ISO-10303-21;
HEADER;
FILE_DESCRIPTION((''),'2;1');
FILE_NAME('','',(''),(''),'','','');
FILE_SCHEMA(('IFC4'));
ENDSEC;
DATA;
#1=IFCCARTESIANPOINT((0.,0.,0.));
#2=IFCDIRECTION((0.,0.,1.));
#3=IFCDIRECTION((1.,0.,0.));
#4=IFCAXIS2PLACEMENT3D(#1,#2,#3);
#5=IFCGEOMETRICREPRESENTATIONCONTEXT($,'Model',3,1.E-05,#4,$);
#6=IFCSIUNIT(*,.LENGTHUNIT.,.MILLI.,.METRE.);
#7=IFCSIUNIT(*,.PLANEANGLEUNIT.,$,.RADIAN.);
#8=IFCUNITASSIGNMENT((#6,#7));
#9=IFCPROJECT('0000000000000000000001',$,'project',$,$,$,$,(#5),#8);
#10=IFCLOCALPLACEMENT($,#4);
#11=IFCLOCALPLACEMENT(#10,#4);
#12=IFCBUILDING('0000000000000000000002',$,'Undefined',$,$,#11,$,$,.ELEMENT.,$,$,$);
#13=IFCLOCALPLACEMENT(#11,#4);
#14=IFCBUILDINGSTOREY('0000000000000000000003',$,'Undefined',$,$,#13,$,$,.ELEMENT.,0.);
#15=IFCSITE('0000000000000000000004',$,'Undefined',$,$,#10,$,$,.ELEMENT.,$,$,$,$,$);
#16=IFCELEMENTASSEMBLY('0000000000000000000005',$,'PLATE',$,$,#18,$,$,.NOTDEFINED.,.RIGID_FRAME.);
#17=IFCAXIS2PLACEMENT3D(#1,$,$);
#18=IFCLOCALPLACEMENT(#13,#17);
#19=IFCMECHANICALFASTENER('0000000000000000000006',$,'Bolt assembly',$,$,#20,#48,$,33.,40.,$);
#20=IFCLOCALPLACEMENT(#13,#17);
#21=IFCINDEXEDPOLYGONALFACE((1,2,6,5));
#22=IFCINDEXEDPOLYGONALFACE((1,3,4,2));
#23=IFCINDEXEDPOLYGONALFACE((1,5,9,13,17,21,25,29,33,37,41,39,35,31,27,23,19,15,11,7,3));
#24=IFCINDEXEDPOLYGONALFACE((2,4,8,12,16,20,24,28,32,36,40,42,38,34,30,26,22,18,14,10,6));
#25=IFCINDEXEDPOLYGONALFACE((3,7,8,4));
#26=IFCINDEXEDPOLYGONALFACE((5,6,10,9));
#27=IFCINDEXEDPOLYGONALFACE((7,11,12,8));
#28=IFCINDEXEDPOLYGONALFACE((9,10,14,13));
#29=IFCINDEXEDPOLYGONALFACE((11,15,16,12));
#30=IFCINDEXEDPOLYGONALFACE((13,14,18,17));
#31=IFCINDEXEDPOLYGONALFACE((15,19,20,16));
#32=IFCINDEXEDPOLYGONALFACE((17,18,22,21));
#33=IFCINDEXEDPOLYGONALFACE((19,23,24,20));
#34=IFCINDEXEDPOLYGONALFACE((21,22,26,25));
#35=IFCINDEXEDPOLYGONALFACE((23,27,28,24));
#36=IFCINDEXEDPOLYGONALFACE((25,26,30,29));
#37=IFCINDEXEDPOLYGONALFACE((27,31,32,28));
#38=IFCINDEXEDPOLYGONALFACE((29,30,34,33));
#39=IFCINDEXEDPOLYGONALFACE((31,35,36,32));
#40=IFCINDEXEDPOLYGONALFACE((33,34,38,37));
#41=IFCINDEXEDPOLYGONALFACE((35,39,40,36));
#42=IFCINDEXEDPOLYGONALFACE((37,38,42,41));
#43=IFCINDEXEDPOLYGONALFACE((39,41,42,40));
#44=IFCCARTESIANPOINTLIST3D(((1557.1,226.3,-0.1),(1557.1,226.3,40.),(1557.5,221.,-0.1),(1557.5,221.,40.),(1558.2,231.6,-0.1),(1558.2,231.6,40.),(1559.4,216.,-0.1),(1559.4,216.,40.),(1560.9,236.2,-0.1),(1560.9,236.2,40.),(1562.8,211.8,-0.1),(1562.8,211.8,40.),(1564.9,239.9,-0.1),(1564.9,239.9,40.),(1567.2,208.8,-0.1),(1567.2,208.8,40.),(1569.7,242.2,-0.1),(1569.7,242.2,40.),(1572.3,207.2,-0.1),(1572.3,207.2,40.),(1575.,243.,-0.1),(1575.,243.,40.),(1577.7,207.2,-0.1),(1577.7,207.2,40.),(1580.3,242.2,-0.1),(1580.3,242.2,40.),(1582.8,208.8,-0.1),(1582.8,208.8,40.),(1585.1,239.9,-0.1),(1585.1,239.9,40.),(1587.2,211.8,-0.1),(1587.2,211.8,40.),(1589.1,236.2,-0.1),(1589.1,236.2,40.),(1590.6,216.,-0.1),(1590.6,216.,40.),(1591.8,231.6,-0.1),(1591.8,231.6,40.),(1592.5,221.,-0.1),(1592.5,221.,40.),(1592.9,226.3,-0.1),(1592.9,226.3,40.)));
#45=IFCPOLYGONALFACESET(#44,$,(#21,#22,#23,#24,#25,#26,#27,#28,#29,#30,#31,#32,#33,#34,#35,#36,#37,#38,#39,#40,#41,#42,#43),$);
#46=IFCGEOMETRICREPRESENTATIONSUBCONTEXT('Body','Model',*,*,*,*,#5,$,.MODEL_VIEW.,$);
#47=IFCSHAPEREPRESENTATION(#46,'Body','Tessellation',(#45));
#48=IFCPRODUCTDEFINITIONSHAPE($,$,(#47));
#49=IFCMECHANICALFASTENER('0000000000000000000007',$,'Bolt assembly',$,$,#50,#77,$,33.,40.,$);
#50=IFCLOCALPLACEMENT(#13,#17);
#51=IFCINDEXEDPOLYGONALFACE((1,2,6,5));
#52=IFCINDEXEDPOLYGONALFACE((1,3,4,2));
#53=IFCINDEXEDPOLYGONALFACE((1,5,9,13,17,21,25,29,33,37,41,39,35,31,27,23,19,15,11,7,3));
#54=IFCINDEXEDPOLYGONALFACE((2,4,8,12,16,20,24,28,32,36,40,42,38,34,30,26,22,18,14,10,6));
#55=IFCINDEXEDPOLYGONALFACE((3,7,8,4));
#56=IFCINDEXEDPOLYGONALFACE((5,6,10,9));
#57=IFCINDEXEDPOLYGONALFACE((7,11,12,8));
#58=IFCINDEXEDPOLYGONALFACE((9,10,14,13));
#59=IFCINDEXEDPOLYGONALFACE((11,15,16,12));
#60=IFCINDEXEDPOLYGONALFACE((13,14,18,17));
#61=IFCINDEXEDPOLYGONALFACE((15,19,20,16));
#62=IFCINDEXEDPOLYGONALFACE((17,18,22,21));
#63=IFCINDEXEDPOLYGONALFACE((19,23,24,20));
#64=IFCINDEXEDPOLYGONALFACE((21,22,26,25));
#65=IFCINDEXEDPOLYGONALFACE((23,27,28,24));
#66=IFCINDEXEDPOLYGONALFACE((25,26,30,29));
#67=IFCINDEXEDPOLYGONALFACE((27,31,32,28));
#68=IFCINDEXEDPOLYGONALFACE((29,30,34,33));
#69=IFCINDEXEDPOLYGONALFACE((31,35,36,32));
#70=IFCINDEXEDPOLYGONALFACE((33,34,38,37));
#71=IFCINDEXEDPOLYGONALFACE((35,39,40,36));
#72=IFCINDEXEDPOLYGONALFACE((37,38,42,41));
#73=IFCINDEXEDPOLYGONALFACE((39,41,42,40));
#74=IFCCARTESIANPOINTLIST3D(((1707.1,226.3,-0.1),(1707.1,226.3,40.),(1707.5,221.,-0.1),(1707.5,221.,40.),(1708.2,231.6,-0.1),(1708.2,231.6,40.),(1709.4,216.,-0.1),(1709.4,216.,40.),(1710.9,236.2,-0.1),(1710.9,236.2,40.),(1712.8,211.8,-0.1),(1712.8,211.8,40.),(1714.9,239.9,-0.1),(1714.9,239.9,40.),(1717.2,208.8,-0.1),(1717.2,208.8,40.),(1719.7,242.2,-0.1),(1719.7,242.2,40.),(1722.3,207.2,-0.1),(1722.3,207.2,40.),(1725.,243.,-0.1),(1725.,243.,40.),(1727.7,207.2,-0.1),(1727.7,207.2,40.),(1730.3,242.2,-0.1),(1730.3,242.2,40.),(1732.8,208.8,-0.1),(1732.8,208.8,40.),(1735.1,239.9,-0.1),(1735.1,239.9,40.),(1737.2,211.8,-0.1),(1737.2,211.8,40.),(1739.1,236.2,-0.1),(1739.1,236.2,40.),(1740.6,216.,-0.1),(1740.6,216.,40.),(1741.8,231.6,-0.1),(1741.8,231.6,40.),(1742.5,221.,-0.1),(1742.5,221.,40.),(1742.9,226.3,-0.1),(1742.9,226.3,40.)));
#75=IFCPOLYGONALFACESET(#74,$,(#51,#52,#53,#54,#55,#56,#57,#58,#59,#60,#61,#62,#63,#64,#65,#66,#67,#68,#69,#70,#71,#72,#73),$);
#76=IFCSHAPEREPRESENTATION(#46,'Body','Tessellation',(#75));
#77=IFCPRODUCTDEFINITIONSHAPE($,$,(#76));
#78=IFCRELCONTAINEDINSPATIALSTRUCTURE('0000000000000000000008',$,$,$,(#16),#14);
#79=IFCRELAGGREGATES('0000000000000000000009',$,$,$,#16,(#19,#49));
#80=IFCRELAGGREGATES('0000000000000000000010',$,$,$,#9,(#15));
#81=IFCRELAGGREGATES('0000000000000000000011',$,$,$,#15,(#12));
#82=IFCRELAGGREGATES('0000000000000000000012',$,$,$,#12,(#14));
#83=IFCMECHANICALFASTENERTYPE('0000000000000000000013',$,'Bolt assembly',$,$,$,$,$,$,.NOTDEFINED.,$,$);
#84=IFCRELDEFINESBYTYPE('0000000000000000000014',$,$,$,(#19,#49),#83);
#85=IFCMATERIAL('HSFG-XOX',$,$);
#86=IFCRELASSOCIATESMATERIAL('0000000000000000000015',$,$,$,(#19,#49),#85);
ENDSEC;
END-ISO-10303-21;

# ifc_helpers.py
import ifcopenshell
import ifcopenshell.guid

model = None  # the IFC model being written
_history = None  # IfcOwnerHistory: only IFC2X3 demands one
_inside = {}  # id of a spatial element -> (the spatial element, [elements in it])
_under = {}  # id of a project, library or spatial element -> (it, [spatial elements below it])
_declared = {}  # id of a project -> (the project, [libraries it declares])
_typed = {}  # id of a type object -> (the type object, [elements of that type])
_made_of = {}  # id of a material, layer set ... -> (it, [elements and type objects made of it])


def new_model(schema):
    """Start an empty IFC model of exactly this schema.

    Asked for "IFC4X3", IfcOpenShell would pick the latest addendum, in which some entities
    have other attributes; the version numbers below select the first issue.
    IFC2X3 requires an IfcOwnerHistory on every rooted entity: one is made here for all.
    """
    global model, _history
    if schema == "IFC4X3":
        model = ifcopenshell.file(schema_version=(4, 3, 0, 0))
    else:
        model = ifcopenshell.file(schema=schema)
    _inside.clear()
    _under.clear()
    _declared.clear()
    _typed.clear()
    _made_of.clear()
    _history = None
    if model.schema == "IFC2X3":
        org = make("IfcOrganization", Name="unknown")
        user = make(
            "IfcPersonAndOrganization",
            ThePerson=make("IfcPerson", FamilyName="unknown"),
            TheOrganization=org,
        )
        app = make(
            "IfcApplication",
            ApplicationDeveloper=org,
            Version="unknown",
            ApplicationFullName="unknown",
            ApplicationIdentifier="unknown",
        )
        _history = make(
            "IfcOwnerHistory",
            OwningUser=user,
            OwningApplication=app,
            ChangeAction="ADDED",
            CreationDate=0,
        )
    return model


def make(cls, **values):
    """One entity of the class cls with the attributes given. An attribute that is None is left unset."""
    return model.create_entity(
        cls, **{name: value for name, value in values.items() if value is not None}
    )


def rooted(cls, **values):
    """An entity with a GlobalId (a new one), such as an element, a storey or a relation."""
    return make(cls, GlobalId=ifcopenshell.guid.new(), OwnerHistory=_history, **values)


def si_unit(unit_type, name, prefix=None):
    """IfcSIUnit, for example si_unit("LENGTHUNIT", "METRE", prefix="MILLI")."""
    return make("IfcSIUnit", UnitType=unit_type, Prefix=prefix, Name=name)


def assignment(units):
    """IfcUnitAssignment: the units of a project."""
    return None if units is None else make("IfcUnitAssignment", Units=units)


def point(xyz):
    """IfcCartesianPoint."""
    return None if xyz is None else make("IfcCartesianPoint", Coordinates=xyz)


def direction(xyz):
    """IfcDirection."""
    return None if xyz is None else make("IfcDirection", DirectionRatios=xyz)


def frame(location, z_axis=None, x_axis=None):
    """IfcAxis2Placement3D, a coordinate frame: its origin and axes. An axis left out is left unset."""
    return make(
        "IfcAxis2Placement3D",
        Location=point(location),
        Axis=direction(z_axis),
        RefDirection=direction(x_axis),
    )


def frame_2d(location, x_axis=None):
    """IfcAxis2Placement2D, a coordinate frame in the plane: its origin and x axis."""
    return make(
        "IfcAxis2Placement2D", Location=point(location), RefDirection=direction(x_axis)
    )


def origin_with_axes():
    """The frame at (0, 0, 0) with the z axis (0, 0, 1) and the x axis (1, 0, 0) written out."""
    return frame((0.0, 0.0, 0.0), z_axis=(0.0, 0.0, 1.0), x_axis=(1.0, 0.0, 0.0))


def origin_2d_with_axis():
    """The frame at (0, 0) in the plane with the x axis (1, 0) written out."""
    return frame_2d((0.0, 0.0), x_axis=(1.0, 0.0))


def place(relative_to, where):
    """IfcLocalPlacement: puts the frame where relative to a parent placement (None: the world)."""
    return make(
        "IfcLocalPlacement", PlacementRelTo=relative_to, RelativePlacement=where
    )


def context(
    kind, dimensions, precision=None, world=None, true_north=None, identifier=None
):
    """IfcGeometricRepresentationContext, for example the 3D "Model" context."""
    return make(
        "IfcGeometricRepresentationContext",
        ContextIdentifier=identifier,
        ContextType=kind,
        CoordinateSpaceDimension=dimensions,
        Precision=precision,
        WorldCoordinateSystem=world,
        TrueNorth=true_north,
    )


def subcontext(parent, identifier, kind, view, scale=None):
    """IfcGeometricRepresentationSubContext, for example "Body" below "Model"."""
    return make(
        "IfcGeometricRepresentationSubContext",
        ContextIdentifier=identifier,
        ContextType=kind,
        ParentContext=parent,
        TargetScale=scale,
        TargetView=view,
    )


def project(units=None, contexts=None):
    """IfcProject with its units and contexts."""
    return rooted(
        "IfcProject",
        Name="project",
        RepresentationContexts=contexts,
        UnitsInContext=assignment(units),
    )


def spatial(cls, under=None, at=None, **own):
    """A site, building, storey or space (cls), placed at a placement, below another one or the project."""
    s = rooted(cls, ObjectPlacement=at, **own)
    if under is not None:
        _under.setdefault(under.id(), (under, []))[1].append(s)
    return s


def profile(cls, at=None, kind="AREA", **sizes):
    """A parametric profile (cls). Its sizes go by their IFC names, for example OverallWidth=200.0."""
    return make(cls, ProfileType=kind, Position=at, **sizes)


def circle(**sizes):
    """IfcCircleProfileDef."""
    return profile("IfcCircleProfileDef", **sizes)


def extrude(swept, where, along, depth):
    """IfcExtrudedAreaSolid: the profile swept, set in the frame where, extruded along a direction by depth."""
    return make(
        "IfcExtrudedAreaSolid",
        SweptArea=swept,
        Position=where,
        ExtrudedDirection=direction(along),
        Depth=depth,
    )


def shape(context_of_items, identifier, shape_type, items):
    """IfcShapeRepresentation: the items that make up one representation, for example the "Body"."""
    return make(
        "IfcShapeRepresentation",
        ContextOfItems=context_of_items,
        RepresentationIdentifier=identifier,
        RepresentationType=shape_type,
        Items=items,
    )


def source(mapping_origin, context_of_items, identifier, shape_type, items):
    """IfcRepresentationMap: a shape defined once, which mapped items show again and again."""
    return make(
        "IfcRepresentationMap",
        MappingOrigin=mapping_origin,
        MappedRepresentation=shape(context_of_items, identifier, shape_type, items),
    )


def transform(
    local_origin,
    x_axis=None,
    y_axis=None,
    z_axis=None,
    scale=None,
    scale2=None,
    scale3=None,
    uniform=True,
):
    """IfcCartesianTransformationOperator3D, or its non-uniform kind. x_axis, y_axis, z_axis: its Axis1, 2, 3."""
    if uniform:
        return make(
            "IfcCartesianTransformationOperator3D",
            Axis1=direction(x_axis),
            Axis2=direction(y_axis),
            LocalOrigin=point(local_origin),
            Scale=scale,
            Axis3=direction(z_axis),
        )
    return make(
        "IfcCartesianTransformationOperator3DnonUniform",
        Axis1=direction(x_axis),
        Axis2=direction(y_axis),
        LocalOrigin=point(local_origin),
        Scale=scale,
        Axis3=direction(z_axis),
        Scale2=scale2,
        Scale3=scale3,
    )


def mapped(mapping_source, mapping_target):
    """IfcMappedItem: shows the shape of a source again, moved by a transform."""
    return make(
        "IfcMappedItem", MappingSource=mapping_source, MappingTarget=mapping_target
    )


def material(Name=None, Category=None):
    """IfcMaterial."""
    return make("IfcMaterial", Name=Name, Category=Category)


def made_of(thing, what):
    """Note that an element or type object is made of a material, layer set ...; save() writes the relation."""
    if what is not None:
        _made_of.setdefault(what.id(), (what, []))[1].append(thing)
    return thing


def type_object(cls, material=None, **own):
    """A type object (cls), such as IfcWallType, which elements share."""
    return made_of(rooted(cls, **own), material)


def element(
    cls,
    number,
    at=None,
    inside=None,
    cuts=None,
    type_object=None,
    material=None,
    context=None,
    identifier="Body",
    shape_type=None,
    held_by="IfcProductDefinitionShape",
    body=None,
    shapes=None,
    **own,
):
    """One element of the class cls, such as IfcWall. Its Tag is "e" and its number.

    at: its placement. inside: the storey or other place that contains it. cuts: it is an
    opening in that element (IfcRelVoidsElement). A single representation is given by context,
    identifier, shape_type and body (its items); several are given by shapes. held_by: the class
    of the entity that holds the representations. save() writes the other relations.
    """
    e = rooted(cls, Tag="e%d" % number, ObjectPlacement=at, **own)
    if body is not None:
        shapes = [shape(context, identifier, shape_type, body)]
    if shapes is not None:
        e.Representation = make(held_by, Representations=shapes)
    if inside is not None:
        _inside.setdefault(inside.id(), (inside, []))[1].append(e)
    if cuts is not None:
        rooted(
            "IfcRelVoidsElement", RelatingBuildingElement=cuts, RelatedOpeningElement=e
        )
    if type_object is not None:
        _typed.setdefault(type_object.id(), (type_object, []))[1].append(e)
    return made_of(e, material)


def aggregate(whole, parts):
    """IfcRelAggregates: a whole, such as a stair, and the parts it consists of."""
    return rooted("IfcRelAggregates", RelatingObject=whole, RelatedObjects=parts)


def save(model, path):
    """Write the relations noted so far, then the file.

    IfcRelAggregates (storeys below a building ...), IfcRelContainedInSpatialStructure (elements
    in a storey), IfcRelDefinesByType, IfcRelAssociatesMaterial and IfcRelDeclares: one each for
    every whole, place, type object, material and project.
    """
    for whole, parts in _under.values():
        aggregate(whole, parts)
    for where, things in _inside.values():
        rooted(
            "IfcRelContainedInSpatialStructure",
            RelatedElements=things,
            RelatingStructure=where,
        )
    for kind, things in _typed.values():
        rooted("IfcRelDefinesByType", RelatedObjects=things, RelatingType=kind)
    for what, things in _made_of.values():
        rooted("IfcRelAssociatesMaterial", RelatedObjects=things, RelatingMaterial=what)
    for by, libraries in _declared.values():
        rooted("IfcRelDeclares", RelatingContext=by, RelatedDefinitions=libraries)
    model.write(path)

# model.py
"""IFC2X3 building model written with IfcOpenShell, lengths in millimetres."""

from ifc_helpers import new_model, si_unit, frame, origin_with_axes, origin_2d_with_axis, place, context, subcontext, project, spatial, circle, extrude, source, transform, mapped, material, type_object, element, aggregate, save


model = new_model("IFC2X3")

# Units and contexts
model_context = context("Model", 3, precision=1e-05, world=origin_with_axes())
body_context = subcontext(model_context, "Body", "Model", "MODEL_VIEW")
ifc_project = project(units=[si_unit("LENGTHUNIT", "METRE", prefix="MILLI"), si_unit("PLANEANGLEUNIT", "RADIAN")], contexts=[model_context])

# Site, building, storey
site_placement = place(None, origin_with_axes())
site = spatial("IfcSite", under=ifc_project, at=site_placement, Name="Undefined", CompositionType="ELEMENT")
building_placement = place(site_placement, origin_with_axes())
building = spatial("IfcBuilding", under=site, at=building_placement, Name="Undefined", CompositionType="ELEMENT")
storey_placement = place(building_placement, origin_with_axes())
storey = spatial("IfcBuildingStorey", under=building, at=storey_placement, Name="Undefined", CompositionType="ELEMENT", Elevation=0.0)

# Element assembly, mechanical fasteners
assembly_1_placement = place(storey_placement, origin_with_axes())
assembly_1 = element("IfcElementAssembly", 1, at=assembly_1_placement, inside=storey, Name="PLATE", AssemblyPlace="NOTDEFINED", PredefinedType="RIGID_FRAME")
ifc_material_1 = material(Name="HSFG-XOX")
mechanical_fastener_type = type_object("IfcMechanicalFastenerType", Name="Bolt assembly")
shared_shape = source(origin_with_axes(), body_context, "Body", "SweptSolid", [
    extrude(circle(Radius=18.0, at=origin_2d_with_axis()), frame((0.0, -40.0, 0.0), z_axis=(0.0, 1.0, 0.0), x_axis=(1.0, 0.0, 0.0)), (0.0, 0.0, 1.0), 40.1),
])
mechanical_fastener_1_placement = place(assembly_1_placement, frame((1575.0, 225.0, 0.0), z_axis=(-1.0, 0.0, 0.0), x_axis=(0.0, 1.0, 0.0)))
mechanical_fastener_1 = element("IfcMechanicalFastener", 2, at=mechanical_fastener_1_placement, type_object=mechanical_fastener_type, material=ifc_material_1, Name="Bolt assembly", NominalDiameter=33.0, NominalLength=40.0, context=body_context, shape_type="MappedRepresentation", body=[
    mapped(shared_shape, transform((0.0, 0.0, 0.0))),
])
mechanical_fastener_2_placement = place(assembly_1_placement, frame((1725.0, 225.0, 0.0), z_axis=(-1.0, 0.0, 0.0), x_axis=(0.0, 1.0, 0.0)))
mechanical_fastener_2 = element("IfcMechanicalFastener", 3, at=mechanical_fastener_2_placement, type_object=mechanical_fastener_type, material=ifc_material_1, Name="Bolt assembly", NominalDiameter=33.0, NominalLength=40.0, context=body_context, shape_type="MappedRepresentation", body=[
    mapped(shared_shape, transform((0.0, 0.0, 0.0))),
])
aggregate(assembly_1, [mechanical_fastener_1, mechanical_fastener_2])

save(model, "model.ifc")
